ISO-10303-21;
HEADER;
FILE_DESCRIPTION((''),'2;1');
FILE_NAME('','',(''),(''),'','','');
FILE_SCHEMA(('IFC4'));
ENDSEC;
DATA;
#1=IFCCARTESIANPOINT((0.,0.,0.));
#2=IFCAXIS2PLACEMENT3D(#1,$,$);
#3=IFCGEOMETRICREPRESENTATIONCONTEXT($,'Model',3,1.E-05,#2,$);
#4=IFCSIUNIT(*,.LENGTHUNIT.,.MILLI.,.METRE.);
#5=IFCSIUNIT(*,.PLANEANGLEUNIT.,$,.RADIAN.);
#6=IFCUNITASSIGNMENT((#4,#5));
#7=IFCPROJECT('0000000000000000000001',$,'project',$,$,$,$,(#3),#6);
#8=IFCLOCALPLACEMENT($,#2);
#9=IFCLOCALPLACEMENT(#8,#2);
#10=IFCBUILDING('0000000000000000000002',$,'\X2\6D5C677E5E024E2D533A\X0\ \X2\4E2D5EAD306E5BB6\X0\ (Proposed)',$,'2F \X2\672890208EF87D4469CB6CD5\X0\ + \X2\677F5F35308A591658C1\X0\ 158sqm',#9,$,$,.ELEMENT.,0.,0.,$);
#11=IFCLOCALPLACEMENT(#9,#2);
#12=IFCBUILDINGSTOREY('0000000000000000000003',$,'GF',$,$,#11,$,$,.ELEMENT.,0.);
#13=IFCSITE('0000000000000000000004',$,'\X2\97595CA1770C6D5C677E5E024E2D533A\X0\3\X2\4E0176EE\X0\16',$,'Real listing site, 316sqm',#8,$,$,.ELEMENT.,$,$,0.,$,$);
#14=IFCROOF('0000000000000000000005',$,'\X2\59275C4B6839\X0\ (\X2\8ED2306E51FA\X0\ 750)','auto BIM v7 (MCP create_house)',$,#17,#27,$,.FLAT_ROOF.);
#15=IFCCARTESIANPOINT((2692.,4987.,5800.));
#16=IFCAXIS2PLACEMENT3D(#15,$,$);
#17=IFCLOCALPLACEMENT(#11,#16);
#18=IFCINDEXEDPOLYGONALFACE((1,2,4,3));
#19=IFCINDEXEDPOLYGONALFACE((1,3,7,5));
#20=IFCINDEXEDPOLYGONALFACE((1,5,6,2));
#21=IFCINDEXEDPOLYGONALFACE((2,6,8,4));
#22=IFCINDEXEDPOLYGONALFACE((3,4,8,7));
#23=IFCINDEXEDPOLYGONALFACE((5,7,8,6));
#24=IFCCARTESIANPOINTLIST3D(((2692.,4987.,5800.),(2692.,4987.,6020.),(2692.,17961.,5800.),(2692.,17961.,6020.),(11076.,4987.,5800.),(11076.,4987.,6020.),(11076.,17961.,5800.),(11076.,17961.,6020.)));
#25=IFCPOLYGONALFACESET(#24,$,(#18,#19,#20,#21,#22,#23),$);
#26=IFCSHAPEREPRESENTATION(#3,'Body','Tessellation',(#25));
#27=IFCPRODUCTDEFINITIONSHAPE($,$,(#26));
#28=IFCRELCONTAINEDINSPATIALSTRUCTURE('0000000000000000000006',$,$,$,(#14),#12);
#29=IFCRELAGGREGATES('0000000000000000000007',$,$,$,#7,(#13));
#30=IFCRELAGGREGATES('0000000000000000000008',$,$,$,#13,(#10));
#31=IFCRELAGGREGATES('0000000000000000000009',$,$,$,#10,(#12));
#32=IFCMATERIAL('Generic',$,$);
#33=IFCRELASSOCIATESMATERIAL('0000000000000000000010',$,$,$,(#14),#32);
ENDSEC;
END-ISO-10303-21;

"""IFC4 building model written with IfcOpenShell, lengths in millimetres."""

from ifc_helpers import new_model, si_unit, frame, frame_2d, origin, place, context, project, spatial, rectangle, extrude, material, element, save


model = new_model("IFC4")

# Units and contexts
model_context = context("Model", 3, precision=1e-05, world=origin())
ifc_project = project(units=[si_unit("LENGTHUNIT", "METRE", prefix="MILLI"), si_unit("PLANEANGLEUNIT", "RADIAN")], contexts=[model_context])

# Site, building, storey
site_placement = place(None, origin())
site = spatial("IfcSite", under=ifc_project, at=site_placement, Name="静岡県浜松市中区3丁目16", ObjectType="Real listing site, 316sqm", CompositionType="ELEMENT", RefElevation=0.0)
building_placement = place(site_placement, origin())
building = spatial("IfcBuilding", under=site, at=building_placement, Name="浜松市中区 中庭の家 (Proposed)", ObjectType="2F 木造軸組構法 + 板張り外壁 158sqm", CompositionType="ELEMENT", ElevationOfRefHeight=0.0, ElevationOfTerrain=0.0)
storey_placement = place(building_placement, origin())
storey = spatial("IfcBuildingStorey", under=building, at=storey_placement, Name="GF", CompositionType="ELEMENT", Elevation=0.0)

# Shared definitions
ifc_material = material(Name="Generic")

# Roof
roof_placement = place(storey_placement, frame((2692.0, 4987.0, 5800.0)))
element("IfcRoof", 1, at=roof_placement, inside=storey, material=ifc_material, Name="大屋根 (軒の出 750)", Description="auto BIM v7 (MCP create_house)", PredefinedType="FLAT_ROOF", context=model_context, shape_type="SweptSolid", body=[
    extrude(rectangle(XDim=8384.0, YDim=12974.0, at=frame_2d((4192.0, 6487.0))), frame((2692.0, 4987.0, 5800.0)), (0.0, 0.0, 1.0), 220.0),
])

save(model, "model.ifc")
